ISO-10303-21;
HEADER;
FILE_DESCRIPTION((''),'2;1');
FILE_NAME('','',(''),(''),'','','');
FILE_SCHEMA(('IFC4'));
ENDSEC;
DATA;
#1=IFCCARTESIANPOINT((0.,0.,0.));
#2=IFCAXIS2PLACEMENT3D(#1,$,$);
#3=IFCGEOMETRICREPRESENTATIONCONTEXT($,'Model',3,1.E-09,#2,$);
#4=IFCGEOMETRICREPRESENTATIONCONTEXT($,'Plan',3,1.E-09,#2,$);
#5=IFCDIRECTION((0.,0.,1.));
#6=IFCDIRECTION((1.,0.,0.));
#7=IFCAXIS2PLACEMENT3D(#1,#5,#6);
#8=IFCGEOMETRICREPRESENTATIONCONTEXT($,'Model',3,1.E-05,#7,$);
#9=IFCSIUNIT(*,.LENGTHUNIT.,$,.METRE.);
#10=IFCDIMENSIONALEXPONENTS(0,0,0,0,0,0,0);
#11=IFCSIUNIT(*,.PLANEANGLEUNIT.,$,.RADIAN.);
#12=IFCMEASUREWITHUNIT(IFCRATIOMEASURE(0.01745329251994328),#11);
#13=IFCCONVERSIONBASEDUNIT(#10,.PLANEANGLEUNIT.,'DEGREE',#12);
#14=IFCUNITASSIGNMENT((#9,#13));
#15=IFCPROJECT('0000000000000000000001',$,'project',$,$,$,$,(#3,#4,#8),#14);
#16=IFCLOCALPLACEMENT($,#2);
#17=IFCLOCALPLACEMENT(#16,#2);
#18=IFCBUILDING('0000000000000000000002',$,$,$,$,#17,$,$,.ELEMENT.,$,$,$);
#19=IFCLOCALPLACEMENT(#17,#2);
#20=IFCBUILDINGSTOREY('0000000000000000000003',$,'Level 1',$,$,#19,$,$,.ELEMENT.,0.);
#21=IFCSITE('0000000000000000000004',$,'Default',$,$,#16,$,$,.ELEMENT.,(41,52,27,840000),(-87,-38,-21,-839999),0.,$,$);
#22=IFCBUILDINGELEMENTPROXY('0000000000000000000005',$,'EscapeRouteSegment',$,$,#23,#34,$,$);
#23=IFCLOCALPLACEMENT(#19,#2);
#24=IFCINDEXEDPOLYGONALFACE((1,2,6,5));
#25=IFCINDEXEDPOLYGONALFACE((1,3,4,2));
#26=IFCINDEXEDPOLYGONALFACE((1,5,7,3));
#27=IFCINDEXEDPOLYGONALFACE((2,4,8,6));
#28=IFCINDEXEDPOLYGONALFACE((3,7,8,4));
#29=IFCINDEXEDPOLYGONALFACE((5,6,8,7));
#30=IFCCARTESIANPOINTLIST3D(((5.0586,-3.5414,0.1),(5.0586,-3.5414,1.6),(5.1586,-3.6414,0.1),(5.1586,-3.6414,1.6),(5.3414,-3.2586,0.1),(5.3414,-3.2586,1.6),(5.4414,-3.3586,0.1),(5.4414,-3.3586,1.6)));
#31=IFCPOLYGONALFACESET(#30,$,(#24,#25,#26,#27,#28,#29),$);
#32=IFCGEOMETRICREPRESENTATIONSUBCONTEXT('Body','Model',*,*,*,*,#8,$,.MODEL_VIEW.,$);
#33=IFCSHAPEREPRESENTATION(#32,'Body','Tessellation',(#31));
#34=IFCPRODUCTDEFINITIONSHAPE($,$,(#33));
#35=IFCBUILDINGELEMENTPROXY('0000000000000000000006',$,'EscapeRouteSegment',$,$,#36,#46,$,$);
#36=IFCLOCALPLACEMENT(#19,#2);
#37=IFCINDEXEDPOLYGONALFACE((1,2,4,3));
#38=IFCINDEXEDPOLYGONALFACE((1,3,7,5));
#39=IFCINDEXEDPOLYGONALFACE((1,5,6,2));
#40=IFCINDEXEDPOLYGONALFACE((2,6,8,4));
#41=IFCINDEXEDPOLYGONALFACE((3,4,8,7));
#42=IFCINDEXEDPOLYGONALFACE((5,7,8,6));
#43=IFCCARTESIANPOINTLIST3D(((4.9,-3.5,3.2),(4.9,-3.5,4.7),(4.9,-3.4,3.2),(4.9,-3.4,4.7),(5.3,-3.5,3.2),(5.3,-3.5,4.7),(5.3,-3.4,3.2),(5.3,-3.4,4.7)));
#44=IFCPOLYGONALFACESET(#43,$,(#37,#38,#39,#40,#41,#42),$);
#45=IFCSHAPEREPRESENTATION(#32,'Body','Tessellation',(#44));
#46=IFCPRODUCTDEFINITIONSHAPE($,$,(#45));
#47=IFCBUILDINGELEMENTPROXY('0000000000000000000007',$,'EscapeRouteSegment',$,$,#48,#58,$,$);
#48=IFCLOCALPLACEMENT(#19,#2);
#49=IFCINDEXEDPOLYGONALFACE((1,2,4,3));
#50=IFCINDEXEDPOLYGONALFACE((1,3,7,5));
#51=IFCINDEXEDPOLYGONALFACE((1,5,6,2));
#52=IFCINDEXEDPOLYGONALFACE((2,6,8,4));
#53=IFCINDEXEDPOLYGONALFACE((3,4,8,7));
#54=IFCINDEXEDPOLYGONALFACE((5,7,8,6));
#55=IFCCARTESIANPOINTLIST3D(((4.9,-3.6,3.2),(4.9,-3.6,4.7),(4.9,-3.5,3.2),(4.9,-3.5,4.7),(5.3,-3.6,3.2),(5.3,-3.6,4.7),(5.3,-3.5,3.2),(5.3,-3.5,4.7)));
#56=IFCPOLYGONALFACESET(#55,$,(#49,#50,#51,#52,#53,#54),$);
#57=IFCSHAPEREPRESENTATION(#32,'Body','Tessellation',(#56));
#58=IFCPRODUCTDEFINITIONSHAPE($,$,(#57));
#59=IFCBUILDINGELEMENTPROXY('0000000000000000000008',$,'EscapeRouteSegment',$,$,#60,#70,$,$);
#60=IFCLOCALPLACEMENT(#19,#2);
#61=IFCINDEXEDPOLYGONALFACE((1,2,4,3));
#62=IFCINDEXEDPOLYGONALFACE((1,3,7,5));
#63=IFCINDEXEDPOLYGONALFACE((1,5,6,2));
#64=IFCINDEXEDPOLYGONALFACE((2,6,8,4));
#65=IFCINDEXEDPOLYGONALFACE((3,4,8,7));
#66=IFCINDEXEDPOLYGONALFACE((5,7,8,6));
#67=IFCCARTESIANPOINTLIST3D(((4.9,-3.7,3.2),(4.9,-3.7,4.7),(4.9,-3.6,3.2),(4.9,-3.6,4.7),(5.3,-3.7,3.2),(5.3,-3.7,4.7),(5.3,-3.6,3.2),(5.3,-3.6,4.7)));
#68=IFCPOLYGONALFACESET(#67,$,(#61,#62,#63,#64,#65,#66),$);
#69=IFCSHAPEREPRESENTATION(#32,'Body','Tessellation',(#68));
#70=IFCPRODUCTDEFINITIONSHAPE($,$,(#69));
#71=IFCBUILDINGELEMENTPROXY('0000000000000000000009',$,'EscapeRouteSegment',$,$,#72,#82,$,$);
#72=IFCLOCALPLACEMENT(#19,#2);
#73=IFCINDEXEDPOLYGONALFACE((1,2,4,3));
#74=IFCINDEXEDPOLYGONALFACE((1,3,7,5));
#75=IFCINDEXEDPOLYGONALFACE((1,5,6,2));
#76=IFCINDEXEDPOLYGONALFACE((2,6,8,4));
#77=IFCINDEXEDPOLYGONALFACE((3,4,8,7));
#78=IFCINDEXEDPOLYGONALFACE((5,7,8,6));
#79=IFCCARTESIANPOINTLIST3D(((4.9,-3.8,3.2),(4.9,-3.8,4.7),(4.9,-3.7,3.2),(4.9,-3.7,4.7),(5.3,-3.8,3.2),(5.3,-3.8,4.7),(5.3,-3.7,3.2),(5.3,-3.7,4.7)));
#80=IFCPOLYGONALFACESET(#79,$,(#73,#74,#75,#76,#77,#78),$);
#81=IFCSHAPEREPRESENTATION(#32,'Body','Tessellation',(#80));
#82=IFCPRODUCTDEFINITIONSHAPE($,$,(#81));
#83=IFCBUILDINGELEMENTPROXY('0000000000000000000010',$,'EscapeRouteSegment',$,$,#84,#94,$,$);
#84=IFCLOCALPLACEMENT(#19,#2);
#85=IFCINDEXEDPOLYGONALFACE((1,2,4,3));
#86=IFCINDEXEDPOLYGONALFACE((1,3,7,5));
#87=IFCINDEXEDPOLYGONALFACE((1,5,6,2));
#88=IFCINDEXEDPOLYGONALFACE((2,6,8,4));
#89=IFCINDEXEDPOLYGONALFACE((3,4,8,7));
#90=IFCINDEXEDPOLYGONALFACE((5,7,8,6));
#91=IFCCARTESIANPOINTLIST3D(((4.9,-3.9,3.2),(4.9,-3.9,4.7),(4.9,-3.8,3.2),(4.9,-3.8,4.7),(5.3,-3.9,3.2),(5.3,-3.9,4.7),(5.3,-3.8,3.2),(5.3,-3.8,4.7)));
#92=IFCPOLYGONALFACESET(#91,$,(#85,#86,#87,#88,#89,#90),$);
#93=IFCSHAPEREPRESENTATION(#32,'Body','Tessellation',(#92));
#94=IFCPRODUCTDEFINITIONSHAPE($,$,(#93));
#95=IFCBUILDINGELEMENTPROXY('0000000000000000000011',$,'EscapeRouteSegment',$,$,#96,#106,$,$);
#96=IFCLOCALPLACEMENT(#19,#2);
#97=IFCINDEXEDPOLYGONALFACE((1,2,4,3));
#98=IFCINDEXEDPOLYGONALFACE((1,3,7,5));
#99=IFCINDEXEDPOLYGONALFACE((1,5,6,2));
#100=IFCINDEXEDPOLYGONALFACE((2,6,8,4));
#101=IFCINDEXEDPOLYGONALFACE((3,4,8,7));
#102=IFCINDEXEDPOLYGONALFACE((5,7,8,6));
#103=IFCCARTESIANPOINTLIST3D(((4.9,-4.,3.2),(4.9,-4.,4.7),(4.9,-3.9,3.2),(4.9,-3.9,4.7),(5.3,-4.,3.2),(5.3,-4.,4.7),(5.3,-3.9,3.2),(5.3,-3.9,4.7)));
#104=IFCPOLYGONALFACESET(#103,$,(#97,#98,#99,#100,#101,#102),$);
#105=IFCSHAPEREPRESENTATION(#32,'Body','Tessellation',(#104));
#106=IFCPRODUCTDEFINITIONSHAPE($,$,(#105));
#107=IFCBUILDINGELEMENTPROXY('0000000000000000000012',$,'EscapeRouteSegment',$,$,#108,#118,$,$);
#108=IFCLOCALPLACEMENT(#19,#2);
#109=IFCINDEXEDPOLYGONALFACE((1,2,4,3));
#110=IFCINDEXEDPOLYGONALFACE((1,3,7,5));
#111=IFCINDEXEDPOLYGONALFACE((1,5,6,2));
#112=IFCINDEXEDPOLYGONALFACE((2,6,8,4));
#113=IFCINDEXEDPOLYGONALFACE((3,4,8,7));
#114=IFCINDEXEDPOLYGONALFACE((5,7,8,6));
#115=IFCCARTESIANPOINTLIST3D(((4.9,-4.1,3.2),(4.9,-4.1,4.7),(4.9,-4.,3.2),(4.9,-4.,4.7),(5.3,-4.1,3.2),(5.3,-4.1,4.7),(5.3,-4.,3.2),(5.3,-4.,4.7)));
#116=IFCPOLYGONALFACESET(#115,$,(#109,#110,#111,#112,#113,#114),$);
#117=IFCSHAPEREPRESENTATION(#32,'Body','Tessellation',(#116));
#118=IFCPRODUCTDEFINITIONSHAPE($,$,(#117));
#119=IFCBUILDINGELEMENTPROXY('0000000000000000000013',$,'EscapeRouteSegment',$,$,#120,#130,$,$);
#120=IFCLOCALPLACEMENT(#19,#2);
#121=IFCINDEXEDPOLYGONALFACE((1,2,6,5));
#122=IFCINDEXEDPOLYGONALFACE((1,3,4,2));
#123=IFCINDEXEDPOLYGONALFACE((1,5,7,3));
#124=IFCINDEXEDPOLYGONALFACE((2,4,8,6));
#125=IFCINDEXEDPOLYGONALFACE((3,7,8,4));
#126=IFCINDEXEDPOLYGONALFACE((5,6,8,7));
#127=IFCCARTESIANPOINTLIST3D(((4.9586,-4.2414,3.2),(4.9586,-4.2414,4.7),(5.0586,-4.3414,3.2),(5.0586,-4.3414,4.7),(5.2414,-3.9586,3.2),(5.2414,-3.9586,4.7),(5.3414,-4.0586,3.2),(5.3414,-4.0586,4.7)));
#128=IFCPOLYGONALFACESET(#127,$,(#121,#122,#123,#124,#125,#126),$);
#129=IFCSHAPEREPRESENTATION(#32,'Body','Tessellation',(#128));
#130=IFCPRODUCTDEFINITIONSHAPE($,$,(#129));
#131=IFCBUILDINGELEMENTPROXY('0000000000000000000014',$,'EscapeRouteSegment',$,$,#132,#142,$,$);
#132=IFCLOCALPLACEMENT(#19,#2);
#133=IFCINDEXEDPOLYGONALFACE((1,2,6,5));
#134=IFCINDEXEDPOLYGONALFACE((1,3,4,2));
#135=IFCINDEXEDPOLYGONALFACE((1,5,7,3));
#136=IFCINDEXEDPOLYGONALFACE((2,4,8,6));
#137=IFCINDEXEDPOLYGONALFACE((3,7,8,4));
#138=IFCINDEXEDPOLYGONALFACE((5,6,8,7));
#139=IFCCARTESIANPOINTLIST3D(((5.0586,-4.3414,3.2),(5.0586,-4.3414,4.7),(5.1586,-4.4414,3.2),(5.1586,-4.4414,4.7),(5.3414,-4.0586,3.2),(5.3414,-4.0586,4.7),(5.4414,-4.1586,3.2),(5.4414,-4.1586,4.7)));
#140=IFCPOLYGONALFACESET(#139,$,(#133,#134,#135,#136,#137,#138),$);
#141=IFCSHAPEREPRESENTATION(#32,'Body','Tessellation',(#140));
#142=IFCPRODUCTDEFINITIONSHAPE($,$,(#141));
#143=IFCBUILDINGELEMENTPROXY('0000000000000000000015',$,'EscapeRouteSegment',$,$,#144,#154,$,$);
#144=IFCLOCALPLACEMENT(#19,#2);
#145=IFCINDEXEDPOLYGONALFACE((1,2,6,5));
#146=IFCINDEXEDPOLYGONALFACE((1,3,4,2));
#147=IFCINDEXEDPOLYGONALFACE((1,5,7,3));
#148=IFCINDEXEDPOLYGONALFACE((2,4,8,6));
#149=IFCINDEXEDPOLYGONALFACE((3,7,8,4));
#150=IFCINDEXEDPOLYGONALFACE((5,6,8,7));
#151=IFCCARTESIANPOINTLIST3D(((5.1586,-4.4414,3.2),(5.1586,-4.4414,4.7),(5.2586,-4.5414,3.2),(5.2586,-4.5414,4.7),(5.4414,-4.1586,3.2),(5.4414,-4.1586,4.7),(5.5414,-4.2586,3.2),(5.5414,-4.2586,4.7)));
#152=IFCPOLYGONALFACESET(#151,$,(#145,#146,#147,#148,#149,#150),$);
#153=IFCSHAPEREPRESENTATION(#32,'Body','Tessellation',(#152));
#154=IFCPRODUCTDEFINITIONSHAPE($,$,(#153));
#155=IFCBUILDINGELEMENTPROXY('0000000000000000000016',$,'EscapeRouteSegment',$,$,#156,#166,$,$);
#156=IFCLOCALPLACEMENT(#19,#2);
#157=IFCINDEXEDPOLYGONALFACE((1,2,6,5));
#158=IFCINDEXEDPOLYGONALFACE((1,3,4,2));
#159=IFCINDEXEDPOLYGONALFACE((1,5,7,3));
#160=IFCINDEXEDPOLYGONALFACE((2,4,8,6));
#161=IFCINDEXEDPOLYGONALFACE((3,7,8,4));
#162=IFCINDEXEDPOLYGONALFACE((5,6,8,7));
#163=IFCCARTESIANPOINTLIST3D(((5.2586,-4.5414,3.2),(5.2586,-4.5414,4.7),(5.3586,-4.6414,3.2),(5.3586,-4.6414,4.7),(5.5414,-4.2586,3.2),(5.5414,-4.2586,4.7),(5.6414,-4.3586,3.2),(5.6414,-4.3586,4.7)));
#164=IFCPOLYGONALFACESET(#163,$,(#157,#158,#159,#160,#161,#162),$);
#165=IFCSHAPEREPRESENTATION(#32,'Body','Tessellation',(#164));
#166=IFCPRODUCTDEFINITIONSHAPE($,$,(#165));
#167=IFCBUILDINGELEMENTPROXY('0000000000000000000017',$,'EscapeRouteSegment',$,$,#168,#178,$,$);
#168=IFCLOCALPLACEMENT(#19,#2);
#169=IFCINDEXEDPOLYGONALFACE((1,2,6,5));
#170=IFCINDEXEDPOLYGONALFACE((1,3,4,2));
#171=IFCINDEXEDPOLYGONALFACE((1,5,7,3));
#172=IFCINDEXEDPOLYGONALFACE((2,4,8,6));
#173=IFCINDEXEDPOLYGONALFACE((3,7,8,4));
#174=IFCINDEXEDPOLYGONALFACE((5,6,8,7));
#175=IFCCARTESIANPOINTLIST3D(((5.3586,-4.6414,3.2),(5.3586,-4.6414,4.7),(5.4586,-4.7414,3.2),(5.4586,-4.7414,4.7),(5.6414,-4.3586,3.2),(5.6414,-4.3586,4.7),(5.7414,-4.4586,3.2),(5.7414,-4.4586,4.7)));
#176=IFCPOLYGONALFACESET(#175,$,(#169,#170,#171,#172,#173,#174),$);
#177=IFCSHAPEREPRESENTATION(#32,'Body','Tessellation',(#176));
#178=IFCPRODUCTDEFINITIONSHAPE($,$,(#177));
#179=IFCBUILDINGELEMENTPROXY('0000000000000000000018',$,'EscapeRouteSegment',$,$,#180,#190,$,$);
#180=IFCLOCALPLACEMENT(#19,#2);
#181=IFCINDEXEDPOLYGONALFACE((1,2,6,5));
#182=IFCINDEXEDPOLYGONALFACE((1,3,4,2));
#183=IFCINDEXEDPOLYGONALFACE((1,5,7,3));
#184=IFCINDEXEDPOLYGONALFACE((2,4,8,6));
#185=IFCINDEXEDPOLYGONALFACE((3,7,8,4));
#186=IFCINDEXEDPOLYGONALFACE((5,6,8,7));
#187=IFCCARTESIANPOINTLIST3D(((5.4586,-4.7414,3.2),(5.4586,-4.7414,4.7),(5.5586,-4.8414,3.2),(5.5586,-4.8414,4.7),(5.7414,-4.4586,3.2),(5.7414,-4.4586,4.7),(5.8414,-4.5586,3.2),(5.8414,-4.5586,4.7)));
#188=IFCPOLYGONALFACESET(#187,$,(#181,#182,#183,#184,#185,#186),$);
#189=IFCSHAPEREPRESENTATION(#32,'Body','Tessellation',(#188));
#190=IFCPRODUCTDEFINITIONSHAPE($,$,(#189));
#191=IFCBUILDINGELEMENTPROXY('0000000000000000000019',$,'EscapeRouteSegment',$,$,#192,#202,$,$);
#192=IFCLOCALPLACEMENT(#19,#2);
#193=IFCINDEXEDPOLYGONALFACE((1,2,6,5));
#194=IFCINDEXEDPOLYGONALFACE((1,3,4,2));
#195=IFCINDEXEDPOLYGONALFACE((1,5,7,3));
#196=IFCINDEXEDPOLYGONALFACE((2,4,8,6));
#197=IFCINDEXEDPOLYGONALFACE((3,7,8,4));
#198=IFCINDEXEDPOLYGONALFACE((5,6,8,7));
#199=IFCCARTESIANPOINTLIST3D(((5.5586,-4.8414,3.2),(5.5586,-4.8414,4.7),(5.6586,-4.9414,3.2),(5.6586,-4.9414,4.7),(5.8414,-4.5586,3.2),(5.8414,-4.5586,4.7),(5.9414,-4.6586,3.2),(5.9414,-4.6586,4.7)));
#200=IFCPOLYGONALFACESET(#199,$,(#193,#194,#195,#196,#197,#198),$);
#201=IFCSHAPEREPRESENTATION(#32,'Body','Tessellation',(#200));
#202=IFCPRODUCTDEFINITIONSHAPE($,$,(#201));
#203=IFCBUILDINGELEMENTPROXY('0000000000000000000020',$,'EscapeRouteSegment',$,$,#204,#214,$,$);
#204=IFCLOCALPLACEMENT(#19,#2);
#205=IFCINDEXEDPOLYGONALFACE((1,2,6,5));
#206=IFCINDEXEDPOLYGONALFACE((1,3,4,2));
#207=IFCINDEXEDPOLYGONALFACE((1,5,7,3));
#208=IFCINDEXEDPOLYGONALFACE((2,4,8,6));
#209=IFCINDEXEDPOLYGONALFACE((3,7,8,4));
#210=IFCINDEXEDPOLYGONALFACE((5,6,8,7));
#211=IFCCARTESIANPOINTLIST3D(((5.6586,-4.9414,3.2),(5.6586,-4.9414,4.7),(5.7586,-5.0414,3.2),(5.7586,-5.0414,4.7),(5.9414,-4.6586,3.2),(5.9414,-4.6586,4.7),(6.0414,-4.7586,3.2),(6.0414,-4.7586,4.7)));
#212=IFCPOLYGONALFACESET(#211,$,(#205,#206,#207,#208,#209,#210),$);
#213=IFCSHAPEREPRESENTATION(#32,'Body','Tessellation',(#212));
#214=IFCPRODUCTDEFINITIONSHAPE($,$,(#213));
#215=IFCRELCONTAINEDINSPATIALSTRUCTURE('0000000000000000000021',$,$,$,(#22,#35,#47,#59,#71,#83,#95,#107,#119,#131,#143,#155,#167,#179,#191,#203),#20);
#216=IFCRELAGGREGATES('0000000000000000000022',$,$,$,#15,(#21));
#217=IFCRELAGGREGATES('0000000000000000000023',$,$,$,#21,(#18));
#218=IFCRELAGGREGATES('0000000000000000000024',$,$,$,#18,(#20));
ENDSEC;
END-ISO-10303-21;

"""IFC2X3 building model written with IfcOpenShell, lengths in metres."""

from ifc_helpers import new_model, entity, si_unit, converted_unit, frame, origin, origin_with_axes, place, context, subcontext, project, spatial, polyline, outline, extrude, element, save


model = new_model("IFC2X3")

# Units and contexts
model_context_1 = context("Model", 3, precision=1e-09, world=origin())
plan_context = context("Plan", 3, precision=1e-09, world=origin())
model_context_2 = context("Model", 3, precision=1e-05, world=origin_with_axes())
body_context = subcontext(model_context_2, "Body", "Model", "MODEL_VIEW")
ifc_project = project(units=[si_unit("LENGTHUNIT", "METRE"), converted_unit("PLANEANGLEUNIT", "DEGREE", entity("IfcRatioMeasure", 0.01745329251994328), si_unit("PLANEANGLEUNIT", "RADIAN"), dimensions=[0, 0, 0, 0, 0, 0, 0])], contexts=[model_context_1, plan_context, model_context_2])

# Site, building, storey
site_placement = place(None, origin())
site = spatial("IfcSite", under=ifc_project, at=site_placement, Name="Default", CompositionType="ELEMENT", RefLatitude=(41, 52, 27, 840000), RefLongitude=(-87, -38, -21, -839999), RefElevation=0.0)
building_placement = place(site_placement, origin())
building = spatial("IfcBuilding", under=site, at=building_placement, CompositionType="ELEMENT")
storey_placement = place(building_placement, origin())
storey = spatial("IfcBuildingStorey", under=building, at=storey_placement, Name="Level 1", CompositionType="ELEMENT", Elevation=0.0)

# Building element proxies
proxy_1_placement = place(storey_placement, frame((5.3, -3.5, 0.1), z_axis=(0.0, 0.0, 1.0), x_axis=(-0.707108, 0.707105, 0.0)))
element("IfcBuildingElementProxy", 1, at=proxy_1_placement, inside=storey, Name="EscapeRouteSegment", context=body_context, shape_type="SweptSolid", body=[
    extrude(outline(polyline([(0.0, -0.2), (0.0, 0.2), (0.1414, 0.2), (0.1414, -0.2), (0.0, -0.2)])), origin_with_axes(), (0.0, 0.0, 1.0), 1.5),
])
for number, where, z_axis, x_axis, name in (
    (2, (5.1, -3.4, 3.2), (0.0, 0.0, 1.0), (0.0, -1.0, 0.0), "EscapeRouteSegment"),
    (3, (5.1, -3.5, 3.2), (0.0, 0.0, 1.0), (0.0, -1.0, 0.0), "EscapeRouteSegment"),
):
    element("IfcBuildingElementProxy", number, at=place(storey_placement, frame(where, z_axis=z_axis, x_axis=x_axis)), inside=storey, Name=name, context=body_context, shape_type="SweptSolid", body=[
        extrude(outline(polyline([(0.0, -0.2), (0.0, 0.2), (0.1, 0.2), (0.1, -0.2), (0.0, -0.2)])), origin_with_axes(), (0.0, 0.0, 1.0), 1.5),
    ])
proxy_2_placement = place(storey_placement, frame((5.1, -3.6, 3.2), z_axis=(0.0, 0.0, 1.0), x_axis=(0.0, -1.0, 0.0)))
element("IfcBuildingElementProxy", 4, at=proxy_2_placement, inside=storey, Name="EscapeRouteSegment", context=body_context, shape_type="SweptSolid", body=[
    extrude(outline(polyline([(0.0, -0.2), (0.0, 0.2), (0.1, 0.2), (0.1, -0.2), (0.0, -0.2)])), origin_with_axes(), (0.0, 0.0, 1.0), 1.5),
])
proxy_3_placement = place(storey_placement, frame((5.1, -3.7, 3.2), z_axis=(0.0, 0.0, 1.0), x_axis=(0.0, -1.0, 0.0)))
element("IfcBuildingElementProxy", 5, at=proxy_3_placement, inside=storey, Name="EscapeRouteSegment", context=body_context, shape_type="SweptSolid", body=[
    extrude(outline(polyline([(0.0, -0.2), (0.0, 0.2), (0.1, 0.2), (0.1, -0.2), (0.0, -0.2)])), origin_with_axes(), (0.0, 0.0, 1.0), 1.5),
])
proxy_4_placement = place(storey_placement, frame((5.1, -3.8, 3.2), z_axis=(0.0, 0.0, 1.0), x_axis=(0.0, -1.0, 0.0)))
element("IfcBuildingElementProxy", 6, at=proxy_4_placement, inside=storey, Name="EscapeRouteSegment", context=body_context, shape_type="SweptSolid", body=[
    extrude(outline(polyline([(0.0, -0.2), (0.0, 0.2), (0.1, 0.2), (0.1, -0.2), (0.0, -0.2)])), origin_with_axes(), (0.0, 0.0, 1.0), 1.5),
])
for number, where, z_axis, x_axis, name in (
    (7, (5.1, -3.9, 3.2), (0.0, 0.0, 1.0), (0.0, -1.0, 0.0), "EscapeRouteSegment"),
    (8, (5.1, -4.0, 3.2), (0.0, 0.0, 1.0), (0.0, -1.0, 0.0), "EscapeRouteSegment"),
):
    element("IfcBuildingElementProxy", number, at=place(storey_placement, frame(where, z_axis=z_axis, x_axis=x_axis)), inside=storey, Name=name, context=body_context, shape_type="SweptSolid", body=[
        extrude(outline(polyline([(0.0, -0.2), (0.0, 0.2), (0.1, 0.2), (0.1, -0.2), (0.0, -0.2)])), origin_with_axes(), (0.0, 0.0, 1.0), 1.5),
    ])
proxy_5_placement = place(storey_placement, frame((5.1, -4.1, 3.2), z_axis=(0.0, 0.0, 1.0), x_axis=(0.707107, -0.707107, 0.0)))
element("IfcBuildingElementProxy", 9, at=proxy_5_placement, inside=storey, Name="EscapeRouteSegment", context=body_context, shape_type="SweptSolid", body=[
    extrude(outline(polyline([(0.0, -0.2), (0.0, 0.2), (0.1414, 0.2), (0.1414, -0.2), (0.0, -0.2)])), origin_with_axes(), (0.0, 0.0, 1.0), 1.5),
])
proxy_6_placement = place(storey_placement, frame((5.2, -4.2, 3.2), z_axis=(0.0, 0.0, 1.0), x_axis=(0.707107, -0.707107, 0.0)))
element("IfcBuildingElementProxy", 10, at=proxy_6_placement, inside=storey, Name="EscapeRouteSegment", context=body_context, shape_type="SweptSolid", body=[
    extrude(outline(polyline([(0.0, -0.2), (0.0, 0.2), (0.1414, 0.2), (0.1414, -0.2), (0.0, -0.2)])), origin_with_axes(), (0.0, 0.0, 1.0), 1.5),
])
for number, where, z_axis, x_axis, name in (
    (11, (5.3, -4.3, 3.2), (0.0, 0.0, 1.0), (0.707107, -0.707107, 0.0), "EscapeRouteSegment"),
    (12, (5.4, -4.4, 3.2), (0.0, 0.0, 1.0), (0.707107, -0.707107, 0.0), "EscapeRouteSegment"),
    (13, (5.5, -4.5, 3.2), (0.0, 0.0, 1.0), (0.707107, -0.707107, 0.0), "EscapeRouteSegment"),
    (14, (5.6, -4.6, 3.2), (0.0, 0.0, 1.0), (0.707107, -0.707107, 0.0), "EscapeRouteSegment"),
):
    element("IfcBuildingElementProxy", number, at=place(storey_placement, frame(where, z_axis=z_axis, x_axis=x_axis)), inside=storey, Name=name, context=body_context, shape_type="SweptSolid", body=[
        extrude(outline(polyline([(0.0, -0.2), (0.0, 0.2), (0.1414, 0.2), (0.1414, -0.2), (0.0, -0.2)])), origin_with_axes(), (0.0, 0.0, 1.0), 1.5),
    ])
proxy_7_placement = place(storey_placement, frame((5.7, -4.7, 3.2), z_axis=(0.0, 0.0, 1.0), x_axis=(0.707107, -0.707107, 0.0)))
element("IfcBuildingElementProxy", 15, at=proxy_7_placement, inside=storey, Name="EscapeRouteSegment", context=body_context, shape_type="SweptSolid", body=[
    extrude(outline(polyline([(0.0, -0.2), (0.0, 0.2), (0.1414, 0.2), (0.1414, -0.2), (0.0, -0.2)])), origin_with_axes(), (0.0, 0.0, 1.0), 1.5),
])
for number, where, z_axis, x_axis, name in (
    (16, (5.8, -4.8, 3.2), (0.0, 0.0, 1.0), (0.707107, -0.707107, 0.0), "EscapeRouteSegment"),
):
    element("IfcBuildingElementProxy", number, at=place(storey_placement, frame(where, z_axis=z_axis, x_axis=x_axis)), inside=storey, Name=name, context=body_context, shape_type="SweptSolid", body=[
        extrude(outline(polyline([(0.0, -0.2), (0.0, 0.2), (0.1414, 0.2), (0.1414, -0.2), (0.0, -0.2)])), origin_with_axes(), (0.0, 0.0, 1.0), 1.5),
    ])

save(model, "model.ifc")
